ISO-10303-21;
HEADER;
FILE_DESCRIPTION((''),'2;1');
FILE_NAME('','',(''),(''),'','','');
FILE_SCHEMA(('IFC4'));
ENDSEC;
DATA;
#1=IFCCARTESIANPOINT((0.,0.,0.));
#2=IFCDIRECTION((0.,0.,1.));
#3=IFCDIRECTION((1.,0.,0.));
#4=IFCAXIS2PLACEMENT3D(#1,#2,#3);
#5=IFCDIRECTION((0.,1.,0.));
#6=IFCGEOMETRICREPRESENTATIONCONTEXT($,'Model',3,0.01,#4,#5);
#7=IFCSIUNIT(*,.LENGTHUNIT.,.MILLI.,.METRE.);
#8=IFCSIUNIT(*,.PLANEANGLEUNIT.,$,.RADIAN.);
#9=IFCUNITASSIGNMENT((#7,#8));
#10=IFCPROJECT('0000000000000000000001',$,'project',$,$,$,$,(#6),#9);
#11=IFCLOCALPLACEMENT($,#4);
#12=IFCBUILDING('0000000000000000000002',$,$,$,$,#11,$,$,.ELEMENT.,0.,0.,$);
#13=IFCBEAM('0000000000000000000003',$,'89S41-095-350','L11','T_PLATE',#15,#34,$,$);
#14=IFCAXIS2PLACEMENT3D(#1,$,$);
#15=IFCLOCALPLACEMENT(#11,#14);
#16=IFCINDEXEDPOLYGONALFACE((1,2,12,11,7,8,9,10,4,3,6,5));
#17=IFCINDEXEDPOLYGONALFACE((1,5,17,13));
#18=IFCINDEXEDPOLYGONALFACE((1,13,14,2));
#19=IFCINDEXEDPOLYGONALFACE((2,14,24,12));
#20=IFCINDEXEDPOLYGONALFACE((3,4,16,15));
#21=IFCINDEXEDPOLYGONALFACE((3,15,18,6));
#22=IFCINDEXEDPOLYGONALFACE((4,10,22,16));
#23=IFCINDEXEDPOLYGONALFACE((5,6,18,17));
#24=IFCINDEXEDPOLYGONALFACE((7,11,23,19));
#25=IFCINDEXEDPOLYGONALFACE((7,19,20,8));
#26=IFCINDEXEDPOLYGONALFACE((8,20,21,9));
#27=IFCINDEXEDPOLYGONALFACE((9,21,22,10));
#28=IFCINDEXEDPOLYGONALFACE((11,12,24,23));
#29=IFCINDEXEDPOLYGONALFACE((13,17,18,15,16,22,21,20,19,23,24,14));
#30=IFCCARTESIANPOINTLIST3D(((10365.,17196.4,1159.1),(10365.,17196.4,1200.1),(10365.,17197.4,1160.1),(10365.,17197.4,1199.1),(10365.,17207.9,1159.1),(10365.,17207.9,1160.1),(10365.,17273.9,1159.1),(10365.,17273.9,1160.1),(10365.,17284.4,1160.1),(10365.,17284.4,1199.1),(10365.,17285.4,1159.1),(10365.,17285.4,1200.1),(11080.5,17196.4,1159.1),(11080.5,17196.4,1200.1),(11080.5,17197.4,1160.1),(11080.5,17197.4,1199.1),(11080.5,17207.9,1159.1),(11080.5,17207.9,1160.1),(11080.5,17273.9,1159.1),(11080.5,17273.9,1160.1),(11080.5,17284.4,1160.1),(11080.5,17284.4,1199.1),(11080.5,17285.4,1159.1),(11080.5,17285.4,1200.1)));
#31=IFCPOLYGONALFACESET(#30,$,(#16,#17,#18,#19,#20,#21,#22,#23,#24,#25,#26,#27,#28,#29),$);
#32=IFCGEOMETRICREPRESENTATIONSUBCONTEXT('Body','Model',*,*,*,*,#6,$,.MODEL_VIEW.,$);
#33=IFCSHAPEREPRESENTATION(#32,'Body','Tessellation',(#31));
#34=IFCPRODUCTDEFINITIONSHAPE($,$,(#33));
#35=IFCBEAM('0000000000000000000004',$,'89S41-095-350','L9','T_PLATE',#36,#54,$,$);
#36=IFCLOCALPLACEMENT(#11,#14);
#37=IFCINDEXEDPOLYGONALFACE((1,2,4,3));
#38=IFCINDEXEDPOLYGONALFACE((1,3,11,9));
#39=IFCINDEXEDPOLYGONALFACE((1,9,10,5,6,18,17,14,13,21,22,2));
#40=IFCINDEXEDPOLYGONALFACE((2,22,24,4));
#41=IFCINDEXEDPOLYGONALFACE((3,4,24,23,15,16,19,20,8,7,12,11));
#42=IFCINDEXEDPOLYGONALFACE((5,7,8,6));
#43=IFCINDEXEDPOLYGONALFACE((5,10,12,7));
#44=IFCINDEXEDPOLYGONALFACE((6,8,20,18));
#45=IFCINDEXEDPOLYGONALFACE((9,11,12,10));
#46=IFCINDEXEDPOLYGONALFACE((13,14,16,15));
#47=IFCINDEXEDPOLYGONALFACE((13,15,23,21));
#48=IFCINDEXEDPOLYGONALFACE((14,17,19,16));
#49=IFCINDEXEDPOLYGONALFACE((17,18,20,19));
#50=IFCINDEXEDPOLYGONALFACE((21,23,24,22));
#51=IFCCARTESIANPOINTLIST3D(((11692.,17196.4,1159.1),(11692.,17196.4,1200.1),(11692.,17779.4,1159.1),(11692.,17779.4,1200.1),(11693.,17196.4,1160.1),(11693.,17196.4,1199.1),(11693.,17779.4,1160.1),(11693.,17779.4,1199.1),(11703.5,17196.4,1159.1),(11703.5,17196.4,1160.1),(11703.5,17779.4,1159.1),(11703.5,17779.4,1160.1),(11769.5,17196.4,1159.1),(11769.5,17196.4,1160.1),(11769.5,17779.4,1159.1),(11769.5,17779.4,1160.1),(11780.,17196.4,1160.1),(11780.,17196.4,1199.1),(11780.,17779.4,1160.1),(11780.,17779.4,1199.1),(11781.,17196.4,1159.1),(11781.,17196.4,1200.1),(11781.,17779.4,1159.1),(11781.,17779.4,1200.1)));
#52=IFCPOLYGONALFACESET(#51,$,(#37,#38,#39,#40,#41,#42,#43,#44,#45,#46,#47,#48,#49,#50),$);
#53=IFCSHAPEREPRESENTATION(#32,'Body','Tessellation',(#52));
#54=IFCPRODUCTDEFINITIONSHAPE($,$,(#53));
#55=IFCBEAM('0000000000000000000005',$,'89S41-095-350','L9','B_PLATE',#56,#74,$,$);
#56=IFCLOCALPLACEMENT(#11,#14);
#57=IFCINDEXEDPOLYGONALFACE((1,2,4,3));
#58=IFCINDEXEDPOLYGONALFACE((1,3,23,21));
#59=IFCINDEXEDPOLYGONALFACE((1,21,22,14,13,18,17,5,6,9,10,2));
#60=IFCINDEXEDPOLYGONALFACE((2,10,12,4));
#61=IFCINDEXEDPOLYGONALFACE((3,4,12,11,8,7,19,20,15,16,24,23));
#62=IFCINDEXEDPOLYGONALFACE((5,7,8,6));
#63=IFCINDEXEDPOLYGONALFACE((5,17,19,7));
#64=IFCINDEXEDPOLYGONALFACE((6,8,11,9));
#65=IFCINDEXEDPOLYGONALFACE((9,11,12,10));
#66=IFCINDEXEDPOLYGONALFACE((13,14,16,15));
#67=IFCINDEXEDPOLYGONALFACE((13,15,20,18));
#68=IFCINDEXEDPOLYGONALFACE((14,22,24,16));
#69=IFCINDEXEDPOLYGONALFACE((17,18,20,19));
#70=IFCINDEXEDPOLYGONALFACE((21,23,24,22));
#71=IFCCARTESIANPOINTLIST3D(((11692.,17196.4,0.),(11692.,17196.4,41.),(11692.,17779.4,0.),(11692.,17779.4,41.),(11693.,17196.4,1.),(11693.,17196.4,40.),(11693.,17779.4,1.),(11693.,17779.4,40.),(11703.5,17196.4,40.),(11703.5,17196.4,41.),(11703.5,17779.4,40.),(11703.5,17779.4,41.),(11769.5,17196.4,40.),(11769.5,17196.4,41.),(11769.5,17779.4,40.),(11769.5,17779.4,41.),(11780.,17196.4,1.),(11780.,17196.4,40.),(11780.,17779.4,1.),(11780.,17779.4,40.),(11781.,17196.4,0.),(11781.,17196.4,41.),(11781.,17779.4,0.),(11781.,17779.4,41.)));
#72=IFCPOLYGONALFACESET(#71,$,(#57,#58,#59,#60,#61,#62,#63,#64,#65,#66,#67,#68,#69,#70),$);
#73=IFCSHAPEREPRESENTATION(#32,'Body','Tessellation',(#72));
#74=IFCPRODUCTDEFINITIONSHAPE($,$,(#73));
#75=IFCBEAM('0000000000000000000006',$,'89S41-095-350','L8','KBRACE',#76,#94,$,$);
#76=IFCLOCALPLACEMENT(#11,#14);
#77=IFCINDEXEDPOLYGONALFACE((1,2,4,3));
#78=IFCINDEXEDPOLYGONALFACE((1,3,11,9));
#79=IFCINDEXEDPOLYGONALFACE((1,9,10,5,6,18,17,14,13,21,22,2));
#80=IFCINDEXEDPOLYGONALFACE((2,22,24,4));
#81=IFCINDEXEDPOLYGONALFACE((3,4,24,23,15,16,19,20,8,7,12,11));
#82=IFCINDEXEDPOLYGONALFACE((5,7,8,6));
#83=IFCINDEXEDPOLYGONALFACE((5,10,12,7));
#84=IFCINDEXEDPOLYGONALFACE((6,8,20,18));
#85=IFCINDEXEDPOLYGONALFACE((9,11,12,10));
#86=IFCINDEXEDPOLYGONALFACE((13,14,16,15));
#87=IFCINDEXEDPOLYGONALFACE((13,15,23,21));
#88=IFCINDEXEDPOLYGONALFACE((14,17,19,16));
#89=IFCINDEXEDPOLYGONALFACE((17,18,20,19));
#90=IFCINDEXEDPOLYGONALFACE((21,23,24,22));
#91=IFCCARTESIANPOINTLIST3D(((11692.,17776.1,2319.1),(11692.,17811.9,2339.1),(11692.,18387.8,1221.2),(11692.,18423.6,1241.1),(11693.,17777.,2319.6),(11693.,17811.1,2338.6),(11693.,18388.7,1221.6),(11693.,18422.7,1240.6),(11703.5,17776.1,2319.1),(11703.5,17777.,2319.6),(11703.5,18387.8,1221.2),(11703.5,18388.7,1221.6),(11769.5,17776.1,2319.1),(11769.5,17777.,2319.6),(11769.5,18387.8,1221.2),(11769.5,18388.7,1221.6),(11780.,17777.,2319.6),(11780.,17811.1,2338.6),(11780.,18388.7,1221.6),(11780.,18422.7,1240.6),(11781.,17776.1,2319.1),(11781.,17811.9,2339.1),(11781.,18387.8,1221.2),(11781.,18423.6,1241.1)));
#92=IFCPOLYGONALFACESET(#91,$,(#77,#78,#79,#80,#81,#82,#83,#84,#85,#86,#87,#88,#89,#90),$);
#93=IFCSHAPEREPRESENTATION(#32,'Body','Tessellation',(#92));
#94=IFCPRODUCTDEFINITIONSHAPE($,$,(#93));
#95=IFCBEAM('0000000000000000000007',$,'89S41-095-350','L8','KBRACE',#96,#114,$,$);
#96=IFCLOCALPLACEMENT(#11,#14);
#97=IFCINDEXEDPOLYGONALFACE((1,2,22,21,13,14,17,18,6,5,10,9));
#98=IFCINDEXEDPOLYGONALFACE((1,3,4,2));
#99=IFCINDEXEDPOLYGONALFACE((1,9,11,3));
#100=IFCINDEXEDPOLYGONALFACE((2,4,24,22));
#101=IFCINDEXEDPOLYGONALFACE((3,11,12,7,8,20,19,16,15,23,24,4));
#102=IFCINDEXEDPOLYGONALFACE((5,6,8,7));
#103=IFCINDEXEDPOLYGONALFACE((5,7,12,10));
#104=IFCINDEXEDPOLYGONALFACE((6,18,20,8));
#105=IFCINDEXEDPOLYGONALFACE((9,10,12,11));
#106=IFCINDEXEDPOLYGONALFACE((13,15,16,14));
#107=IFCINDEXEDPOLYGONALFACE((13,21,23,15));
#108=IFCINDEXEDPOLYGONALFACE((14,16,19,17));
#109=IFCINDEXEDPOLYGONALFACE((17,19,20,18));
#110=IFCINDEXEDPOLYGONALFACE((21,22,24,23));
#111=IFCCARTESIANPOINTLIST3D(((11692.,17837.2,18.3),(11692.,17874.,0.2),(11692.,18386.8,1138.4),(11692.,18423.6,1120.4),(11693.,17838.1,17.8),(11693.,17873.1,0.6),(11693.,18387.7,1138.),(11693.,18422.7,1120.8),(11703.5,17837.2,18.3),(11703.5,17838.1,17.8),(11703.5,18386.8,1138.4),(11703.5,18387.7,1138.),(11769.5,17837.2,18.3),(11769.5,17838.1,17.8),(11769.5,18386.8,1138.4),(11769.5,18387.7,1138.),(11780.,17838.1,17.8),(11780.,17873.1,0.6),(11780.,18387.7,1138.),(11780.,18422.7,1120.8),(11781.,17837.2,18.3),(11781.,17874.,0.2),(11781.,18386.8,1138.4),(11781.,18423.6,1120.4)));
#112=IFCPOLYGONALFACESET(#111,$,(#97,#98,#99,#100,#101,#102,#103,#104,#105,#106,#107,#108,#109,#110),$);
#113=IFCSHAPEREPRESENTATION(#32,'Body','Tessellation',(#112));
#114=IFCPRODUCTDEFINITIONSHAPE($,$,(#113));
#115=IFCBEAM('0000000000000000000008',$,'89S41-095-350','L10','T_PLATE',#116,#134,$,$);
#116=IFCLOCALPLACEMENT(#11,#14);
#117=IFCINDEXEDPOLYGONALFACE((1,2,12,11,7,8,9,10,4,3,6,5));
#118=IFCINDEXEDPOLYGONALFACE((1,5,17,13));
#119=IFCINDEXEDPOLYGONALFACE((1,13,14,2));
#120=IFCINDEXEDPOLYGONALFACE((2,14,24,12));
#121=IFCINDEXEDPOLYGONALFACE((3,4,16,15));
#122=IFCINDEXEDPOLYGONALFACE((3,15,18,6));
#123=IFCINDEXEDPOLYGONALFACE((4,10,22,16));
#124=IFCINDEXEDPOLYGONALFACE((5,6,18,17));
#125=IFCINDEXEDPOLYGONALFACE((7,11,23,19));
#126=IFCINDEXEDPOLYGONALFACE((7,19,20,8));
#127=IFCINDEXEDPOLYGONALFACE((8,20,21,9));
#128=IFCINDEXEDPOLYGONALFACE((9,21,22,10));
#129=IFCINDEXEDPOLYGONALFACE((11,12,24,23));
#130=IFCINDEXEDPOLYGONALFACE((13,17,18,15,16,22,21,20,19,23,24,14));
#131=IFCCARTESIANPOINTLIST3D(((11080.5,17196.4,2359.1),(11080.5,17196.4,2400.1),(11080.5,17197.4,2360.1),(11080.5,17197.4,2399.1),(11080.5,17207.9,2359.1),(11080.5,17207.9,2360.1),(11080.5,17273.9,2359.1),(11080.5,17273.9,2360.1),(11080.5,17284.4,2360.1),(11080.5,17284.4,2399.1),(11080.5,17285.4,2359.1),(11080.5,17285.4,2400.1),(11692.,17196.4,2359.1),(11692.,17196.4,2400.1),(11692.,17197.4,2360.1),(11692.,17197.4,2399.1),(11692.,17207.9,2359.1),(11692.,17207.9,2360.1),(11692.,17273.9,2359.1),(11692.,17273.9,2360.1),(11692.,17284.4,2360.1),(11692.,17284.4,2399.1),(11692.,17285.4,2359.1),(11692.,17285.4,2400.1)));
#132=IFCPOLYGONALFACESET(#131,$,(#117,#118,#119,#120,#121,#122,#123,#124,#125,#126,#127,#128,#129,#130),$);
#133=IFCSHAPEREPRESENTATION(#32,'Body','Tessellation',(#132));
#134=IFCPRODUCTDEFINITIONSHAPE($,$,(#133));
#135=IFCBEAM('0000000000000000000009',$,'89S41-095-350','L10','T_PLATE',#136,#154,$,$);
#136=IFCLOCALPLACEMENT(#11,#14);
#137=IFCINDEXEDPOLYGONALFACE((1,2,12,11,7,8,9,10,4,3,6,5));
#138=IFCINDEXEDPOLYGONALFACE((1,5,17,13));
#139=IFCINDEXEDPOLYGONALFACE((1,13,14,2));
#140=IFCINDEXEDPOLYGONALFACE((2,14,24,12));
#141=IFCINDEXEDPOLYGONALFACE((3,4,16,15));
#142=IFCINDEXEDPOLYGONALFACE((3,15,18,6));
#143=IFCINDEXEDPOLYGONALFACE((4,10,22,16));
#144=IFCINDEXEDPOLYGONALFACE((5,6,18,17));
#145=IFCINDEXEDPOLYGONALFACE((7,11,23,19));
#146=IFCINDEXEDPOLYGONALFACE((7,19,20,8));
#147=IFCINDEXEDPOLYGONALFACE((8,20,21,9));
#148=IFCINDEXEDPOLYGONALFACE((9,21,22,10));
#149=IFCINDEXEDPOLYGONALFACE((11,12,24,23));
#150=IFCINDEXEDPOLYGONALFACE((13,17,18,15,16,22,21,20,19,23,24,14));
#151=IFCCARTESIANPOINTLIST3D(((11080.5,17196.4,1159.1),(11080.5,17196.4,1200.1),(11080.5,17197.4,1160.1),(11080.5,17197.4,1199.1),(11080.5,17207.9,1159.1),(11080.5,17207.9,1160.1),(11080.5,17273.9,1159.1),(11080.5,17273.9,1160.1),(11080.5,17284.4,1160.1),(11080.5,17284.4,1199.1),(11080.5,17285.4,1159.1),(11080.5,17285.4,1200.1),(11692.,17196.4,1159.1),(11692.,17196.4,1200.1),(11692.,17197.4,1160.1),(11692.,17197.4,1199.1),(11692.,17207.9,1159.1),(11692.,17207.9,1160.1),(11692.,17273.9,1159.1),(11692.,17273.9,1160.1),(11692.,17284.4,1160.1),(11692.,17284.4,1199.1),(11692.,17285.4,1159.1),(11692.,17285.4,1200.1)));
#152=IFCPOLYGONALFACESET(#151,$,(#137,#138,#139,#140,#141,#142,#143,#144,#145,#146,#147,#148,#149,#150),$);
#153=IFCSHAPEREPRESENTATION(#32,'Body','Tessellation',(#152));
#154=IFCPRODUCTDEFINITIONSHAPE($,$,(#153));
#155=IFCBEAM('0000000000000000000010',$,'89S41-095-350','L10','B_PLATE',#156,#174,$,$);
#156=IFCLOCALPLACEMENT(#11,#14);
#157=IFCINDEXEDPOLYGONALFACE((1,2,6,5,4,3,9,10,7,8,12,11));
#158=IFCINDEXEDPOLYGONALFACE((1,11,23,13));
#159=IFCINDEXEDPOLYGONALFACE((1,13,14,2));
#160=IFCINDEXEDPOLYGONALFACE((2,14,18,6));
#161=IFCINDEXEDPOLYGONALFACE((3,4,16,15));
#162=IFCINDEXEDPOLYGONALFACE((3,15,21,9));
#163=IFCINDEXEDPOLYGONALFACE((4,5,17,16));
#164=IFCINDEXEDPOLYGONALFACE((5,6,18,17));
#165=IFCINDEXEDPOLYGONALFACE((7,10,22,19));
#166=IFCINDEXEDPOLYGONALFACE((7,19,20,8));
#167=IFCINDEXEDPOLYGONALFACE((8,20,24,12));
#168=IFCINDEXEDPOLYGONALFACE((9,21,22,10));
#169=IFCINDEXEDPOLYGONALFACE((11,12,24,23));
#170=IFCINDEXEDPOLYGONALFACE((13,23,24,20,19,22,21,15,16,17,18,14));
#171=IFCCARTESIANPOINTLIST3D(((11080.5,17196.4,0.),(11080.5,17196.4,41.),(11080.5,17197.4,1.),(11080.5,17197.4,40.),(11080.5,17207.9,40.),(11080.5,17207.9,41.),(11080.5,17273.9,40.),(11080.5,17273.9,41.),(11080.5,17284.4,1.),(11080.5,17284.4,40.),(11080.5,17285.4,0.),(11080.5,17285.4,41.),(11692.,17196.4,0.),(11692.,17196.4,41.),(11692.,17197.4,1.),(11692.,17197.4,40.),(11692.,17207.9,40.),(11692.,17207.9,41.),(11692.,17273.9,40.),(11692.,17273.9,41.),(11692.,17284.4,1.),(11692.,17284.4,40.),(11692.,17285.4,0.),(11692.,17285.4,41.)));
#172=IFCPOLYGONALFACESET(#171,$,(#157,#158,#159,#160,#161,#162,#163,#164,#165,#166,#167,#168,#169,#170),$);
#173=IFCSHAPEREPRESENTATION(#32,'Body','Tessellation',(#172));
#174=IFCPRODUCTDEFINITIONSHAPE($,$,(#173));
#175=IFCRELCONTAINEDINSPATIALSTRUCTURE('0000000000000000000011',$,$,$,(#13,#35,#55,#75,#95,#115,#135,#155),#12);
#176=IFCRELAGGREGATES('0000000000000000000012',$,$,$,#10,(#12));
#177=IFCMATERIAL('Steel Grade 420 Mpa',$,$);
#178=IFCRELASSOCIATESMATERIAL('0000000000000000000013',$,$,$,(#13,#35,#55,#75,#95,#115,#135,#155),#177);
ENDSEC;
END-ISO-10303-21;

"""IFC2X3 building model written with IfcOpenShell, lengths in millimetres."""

from ifc_helpers import new_model, si_unit, direction, frame, origin, origin_with_axes, origin_2d_with_axis, place, context, subcontext, project, spatial, c_section, extrude, source, transform, mapped, material, element, save


model = new_model("IFC2X3")

# Units and contexts
model_context = context("Model", 3, precision=0.01, world=origin_with_axes(), true_north=direction((0.0, 1.0, 0.0)))
body_context = subcontext(model_context, "Body", "Model", "MODEL_VIEW")
ifc_project = project(units=[si_unit("LENGTHUNIT", "METRE", prefix="MILLI"), si_unit("PLANEANGLEUNIT", "RADIAN")], contexts=[model_context])

# Building
building_placement = place(None, origin_with_axes())
building = spatial("IfcBuilding", under=ifc_project, at=building_placement, CompositionType="ELEMENT", ElevationOfRefHeight=0.0, ElevationOfTerrain=0.0)

# Shared definitions
ifc_material = material(Name="Steel Grade 420 Mpa")

# Beams
shared_shape_1 = source(origin(), body_context, "Body", "SweptSolid", [
    extrude(c_section(Depth=89.0, Width=41.0, WallThickness=1.0, Girth=11.5, at=origin_2d_with_axis()), origin_with_axes(), (0.0, 0.0, 1.0), 715.5),
])
beam_1_placement = place(None, frame((10365.0, 17240.9, 1179.6), z_axis=(1.0, 0.0, 0.0), x_axis=(0.0, 0.0, -1.0)))
element("IfcBeam", 1, at=beam_1_placement, inside=building, material=ifc_material, Name="89S41-095-350", Description="L11", ObjectType="T_PLATE", context=body_context, shape_type="MappedRepresentation", body=[
    mapped(shared_shape_1, transform((0.0, 0.0, 0.0), scale=1.0)),
])
shared_shape_2 = source(origin(), body_context, "Body", "SweptSolid", [
    extrude(c_section(Depth=89.0, Width=41.0, WallThickness=1.0, Girth=11.5, at=origin_2d_with_axis()), origin_with_axes(), (0.0, 0.0, 1.0), 583.0),
])
beam_2_placement = place(None, frame((11736.5, 17779.4, 1179.6), z_axis=(0.0, -1.0, 0.0), x_axis=(0.0, 0.0, -1.0)))
element("IfcBeam", 2, at=beam_2_placement, inside=building, material=ifc_material, Name="89S41-095-350", Description="L9", ObjectType="T_PLATE", context=body_context, shape_type="MappedRepresentation", body=[
    mapped(shared_shape_2, transform((0.0, 0.0, 0.0), scale=1.0)),
])
shared_shape_3 = source(origin(), body_context, "Body", "SweptSolid", [
    extrude(c_section(Depth=89.0, Width=41.0, WallThickness=1.0, Girth=11.5, at=origin_2d_with_axis()), origin_with_axes(), (0.0, 0.0, 1.0), 583.0),
])
beam_3_placement = place(None, frame((11736.5, 17779.4, 20.5), z_axis=(0.0, -1.0, 0.0), x_axis=(0.0, 0.0, 1.0)))
element("IfcBeam", 3, at=beam_3_placement, inside=building, material=ifc_material, Name="89S41-095-350", Description="L9", ObjectType="B_PLATE", context=body_context, shape_type="MappedRepresentation", body=[
    mapped(shared_shape_3, transform((0.0, 0.0, 0.0), scale=1.0)),
])
shared_shape_4 = source(origin(), body_context, "Body", "SweptSolid", [
    extrude(c_section(Depth=89.0, Width=41.0, WallThickness=1.0, Girth=11.5, at=origin_2d_with_axis()), origin_with_axes(), (0.0, 0.0, 1.0), 1256.9),
])
beam_4_placement = place(None, frame((11736.5, 18405.7, 1231.1), z_axis=(0.0, -0.486676, 0.873583), x_axis=(0.0, -0.873583, -0.486676)))
element("IfcBeam", 4, at=beam_4_placement, inside=building, material=ifc_material, Name="89S41-095-350", Description="L8", ObjectType="KBRACE", context=body_context, shape_type="MappedRepresentation", body=[
    mapped(shared_shape_4, transform((0.0, 0.0, 0.0), scale=1.0)),
])
shared_shape_5 = source(origin(), body_context, "Body", "SweptSolid", [
    extrude(c_section(Depth=89.0, Width=41.0, WallThickness=1.0, Girth=11.5, at=origin_2d_with_axis()), origin_with_axes(), (0.0, 0.0, 1.0), 1247.7),
])
beam_5_placement = place(None, frame((11736.5, 17855.6, 9.2), z_axis=(0.0, 0.440455, 0.897774), x_axis=(0.0, -0.897774, 0.440455)))
element("IfcBeam", 5, at=beam_5_placement, inside=building, material=ifc_material, Name="89S41-095-350", Description="L8", ObjectType="KBRACE", context=body_context, shape_type="MappedRepresentation", body=[
    mapped(shared_shape_5, transform((0.0, 0.0, 0.0), scale=1.0)),
])
shared_shape_6 = source(origin(), body_context, "Body", "SweptSolid", [
    extrude(c_section(Depth=89.0, Width=41.0, WallThickness=1.0, Girth=11.5, at=origin_2d_with_axis()), origin_with_axes(), (0.0, 0.0, 1.0), 611.5),
])
beam_6_placement = place(None, frame((11080.5, 17240.9, 2379.6), z_axis=(1.0, 0.0, 0.0), x_axis=(0.0, 0.0, -1.0)))
element("IfcBeam", 6, at=beam_6_placement, inside=building, material=ifc_material, Name="89S41-095-350", Description="L10", ObjectType="T_PLATE", context=body_context, shape_type="MappedRepresentation", body=[
    mapped(shared_shape_6, transform((0.0, 0.0, 0.0), scale=1.0)),
])
shared_shape_7 = source(origin(), body_context, "Body", "SweptSolid", [
    extrude(c_section(Depth=89.0, Width=41.0, WallThickness=1.0, Girth=11.5, at=origin_2d_with_axis()), origin_with_axes(), (0.0, 0.0, 1.0), 611.5),
])
beam_7_placement = place(None, frame((11080.5, 17240.9, 1179.6), z_axis=(1.0, 0.0, 0.0), x_axis=(0.0, 0.0, -1.0)))
element("IfcBeam", 7, at=beam_7_placement, inside=building, material=ifc_material, Name="89S41-095-350", Description="L10", ObjectType="T_PLATE", context=body_context, shape_type="MappedRepresentation", body=[
    mapped(shared_shape_7, transform((0.0, 0.0, 0.0), scale=1.0)),
])
shared_shape_8 = source(origin(), body_context, "Body", "SweptSolid", [
    extrude(c_section(Depth=89.0, Width=41.0, WallThickness=1.0, Girth=11.5, at=origin_2d_with_axis()), origin_with_axes(), (0.0, 0.0, 1.0), 611.5),
])
beam_8_placement = place(None, frame((11080.5, 17240.9, 20.5), z_axis=(1.0, 0.0, 0.0), x_axis=(0.0, 0.0, 1.0)))
element("IfcBeam", 8, at=beam_8_placement, inside=building, material=ifc_material, Name="89S41-095-350", Description="L10", ObjectType="B_PLATE", context=body_context, shape_type="MappedRepresentation", body=[
    mapped(shared_shape_8, transform((0.0, 0.0, 0.0), scale=1.0)),
])

save(model, "model.ifc")
